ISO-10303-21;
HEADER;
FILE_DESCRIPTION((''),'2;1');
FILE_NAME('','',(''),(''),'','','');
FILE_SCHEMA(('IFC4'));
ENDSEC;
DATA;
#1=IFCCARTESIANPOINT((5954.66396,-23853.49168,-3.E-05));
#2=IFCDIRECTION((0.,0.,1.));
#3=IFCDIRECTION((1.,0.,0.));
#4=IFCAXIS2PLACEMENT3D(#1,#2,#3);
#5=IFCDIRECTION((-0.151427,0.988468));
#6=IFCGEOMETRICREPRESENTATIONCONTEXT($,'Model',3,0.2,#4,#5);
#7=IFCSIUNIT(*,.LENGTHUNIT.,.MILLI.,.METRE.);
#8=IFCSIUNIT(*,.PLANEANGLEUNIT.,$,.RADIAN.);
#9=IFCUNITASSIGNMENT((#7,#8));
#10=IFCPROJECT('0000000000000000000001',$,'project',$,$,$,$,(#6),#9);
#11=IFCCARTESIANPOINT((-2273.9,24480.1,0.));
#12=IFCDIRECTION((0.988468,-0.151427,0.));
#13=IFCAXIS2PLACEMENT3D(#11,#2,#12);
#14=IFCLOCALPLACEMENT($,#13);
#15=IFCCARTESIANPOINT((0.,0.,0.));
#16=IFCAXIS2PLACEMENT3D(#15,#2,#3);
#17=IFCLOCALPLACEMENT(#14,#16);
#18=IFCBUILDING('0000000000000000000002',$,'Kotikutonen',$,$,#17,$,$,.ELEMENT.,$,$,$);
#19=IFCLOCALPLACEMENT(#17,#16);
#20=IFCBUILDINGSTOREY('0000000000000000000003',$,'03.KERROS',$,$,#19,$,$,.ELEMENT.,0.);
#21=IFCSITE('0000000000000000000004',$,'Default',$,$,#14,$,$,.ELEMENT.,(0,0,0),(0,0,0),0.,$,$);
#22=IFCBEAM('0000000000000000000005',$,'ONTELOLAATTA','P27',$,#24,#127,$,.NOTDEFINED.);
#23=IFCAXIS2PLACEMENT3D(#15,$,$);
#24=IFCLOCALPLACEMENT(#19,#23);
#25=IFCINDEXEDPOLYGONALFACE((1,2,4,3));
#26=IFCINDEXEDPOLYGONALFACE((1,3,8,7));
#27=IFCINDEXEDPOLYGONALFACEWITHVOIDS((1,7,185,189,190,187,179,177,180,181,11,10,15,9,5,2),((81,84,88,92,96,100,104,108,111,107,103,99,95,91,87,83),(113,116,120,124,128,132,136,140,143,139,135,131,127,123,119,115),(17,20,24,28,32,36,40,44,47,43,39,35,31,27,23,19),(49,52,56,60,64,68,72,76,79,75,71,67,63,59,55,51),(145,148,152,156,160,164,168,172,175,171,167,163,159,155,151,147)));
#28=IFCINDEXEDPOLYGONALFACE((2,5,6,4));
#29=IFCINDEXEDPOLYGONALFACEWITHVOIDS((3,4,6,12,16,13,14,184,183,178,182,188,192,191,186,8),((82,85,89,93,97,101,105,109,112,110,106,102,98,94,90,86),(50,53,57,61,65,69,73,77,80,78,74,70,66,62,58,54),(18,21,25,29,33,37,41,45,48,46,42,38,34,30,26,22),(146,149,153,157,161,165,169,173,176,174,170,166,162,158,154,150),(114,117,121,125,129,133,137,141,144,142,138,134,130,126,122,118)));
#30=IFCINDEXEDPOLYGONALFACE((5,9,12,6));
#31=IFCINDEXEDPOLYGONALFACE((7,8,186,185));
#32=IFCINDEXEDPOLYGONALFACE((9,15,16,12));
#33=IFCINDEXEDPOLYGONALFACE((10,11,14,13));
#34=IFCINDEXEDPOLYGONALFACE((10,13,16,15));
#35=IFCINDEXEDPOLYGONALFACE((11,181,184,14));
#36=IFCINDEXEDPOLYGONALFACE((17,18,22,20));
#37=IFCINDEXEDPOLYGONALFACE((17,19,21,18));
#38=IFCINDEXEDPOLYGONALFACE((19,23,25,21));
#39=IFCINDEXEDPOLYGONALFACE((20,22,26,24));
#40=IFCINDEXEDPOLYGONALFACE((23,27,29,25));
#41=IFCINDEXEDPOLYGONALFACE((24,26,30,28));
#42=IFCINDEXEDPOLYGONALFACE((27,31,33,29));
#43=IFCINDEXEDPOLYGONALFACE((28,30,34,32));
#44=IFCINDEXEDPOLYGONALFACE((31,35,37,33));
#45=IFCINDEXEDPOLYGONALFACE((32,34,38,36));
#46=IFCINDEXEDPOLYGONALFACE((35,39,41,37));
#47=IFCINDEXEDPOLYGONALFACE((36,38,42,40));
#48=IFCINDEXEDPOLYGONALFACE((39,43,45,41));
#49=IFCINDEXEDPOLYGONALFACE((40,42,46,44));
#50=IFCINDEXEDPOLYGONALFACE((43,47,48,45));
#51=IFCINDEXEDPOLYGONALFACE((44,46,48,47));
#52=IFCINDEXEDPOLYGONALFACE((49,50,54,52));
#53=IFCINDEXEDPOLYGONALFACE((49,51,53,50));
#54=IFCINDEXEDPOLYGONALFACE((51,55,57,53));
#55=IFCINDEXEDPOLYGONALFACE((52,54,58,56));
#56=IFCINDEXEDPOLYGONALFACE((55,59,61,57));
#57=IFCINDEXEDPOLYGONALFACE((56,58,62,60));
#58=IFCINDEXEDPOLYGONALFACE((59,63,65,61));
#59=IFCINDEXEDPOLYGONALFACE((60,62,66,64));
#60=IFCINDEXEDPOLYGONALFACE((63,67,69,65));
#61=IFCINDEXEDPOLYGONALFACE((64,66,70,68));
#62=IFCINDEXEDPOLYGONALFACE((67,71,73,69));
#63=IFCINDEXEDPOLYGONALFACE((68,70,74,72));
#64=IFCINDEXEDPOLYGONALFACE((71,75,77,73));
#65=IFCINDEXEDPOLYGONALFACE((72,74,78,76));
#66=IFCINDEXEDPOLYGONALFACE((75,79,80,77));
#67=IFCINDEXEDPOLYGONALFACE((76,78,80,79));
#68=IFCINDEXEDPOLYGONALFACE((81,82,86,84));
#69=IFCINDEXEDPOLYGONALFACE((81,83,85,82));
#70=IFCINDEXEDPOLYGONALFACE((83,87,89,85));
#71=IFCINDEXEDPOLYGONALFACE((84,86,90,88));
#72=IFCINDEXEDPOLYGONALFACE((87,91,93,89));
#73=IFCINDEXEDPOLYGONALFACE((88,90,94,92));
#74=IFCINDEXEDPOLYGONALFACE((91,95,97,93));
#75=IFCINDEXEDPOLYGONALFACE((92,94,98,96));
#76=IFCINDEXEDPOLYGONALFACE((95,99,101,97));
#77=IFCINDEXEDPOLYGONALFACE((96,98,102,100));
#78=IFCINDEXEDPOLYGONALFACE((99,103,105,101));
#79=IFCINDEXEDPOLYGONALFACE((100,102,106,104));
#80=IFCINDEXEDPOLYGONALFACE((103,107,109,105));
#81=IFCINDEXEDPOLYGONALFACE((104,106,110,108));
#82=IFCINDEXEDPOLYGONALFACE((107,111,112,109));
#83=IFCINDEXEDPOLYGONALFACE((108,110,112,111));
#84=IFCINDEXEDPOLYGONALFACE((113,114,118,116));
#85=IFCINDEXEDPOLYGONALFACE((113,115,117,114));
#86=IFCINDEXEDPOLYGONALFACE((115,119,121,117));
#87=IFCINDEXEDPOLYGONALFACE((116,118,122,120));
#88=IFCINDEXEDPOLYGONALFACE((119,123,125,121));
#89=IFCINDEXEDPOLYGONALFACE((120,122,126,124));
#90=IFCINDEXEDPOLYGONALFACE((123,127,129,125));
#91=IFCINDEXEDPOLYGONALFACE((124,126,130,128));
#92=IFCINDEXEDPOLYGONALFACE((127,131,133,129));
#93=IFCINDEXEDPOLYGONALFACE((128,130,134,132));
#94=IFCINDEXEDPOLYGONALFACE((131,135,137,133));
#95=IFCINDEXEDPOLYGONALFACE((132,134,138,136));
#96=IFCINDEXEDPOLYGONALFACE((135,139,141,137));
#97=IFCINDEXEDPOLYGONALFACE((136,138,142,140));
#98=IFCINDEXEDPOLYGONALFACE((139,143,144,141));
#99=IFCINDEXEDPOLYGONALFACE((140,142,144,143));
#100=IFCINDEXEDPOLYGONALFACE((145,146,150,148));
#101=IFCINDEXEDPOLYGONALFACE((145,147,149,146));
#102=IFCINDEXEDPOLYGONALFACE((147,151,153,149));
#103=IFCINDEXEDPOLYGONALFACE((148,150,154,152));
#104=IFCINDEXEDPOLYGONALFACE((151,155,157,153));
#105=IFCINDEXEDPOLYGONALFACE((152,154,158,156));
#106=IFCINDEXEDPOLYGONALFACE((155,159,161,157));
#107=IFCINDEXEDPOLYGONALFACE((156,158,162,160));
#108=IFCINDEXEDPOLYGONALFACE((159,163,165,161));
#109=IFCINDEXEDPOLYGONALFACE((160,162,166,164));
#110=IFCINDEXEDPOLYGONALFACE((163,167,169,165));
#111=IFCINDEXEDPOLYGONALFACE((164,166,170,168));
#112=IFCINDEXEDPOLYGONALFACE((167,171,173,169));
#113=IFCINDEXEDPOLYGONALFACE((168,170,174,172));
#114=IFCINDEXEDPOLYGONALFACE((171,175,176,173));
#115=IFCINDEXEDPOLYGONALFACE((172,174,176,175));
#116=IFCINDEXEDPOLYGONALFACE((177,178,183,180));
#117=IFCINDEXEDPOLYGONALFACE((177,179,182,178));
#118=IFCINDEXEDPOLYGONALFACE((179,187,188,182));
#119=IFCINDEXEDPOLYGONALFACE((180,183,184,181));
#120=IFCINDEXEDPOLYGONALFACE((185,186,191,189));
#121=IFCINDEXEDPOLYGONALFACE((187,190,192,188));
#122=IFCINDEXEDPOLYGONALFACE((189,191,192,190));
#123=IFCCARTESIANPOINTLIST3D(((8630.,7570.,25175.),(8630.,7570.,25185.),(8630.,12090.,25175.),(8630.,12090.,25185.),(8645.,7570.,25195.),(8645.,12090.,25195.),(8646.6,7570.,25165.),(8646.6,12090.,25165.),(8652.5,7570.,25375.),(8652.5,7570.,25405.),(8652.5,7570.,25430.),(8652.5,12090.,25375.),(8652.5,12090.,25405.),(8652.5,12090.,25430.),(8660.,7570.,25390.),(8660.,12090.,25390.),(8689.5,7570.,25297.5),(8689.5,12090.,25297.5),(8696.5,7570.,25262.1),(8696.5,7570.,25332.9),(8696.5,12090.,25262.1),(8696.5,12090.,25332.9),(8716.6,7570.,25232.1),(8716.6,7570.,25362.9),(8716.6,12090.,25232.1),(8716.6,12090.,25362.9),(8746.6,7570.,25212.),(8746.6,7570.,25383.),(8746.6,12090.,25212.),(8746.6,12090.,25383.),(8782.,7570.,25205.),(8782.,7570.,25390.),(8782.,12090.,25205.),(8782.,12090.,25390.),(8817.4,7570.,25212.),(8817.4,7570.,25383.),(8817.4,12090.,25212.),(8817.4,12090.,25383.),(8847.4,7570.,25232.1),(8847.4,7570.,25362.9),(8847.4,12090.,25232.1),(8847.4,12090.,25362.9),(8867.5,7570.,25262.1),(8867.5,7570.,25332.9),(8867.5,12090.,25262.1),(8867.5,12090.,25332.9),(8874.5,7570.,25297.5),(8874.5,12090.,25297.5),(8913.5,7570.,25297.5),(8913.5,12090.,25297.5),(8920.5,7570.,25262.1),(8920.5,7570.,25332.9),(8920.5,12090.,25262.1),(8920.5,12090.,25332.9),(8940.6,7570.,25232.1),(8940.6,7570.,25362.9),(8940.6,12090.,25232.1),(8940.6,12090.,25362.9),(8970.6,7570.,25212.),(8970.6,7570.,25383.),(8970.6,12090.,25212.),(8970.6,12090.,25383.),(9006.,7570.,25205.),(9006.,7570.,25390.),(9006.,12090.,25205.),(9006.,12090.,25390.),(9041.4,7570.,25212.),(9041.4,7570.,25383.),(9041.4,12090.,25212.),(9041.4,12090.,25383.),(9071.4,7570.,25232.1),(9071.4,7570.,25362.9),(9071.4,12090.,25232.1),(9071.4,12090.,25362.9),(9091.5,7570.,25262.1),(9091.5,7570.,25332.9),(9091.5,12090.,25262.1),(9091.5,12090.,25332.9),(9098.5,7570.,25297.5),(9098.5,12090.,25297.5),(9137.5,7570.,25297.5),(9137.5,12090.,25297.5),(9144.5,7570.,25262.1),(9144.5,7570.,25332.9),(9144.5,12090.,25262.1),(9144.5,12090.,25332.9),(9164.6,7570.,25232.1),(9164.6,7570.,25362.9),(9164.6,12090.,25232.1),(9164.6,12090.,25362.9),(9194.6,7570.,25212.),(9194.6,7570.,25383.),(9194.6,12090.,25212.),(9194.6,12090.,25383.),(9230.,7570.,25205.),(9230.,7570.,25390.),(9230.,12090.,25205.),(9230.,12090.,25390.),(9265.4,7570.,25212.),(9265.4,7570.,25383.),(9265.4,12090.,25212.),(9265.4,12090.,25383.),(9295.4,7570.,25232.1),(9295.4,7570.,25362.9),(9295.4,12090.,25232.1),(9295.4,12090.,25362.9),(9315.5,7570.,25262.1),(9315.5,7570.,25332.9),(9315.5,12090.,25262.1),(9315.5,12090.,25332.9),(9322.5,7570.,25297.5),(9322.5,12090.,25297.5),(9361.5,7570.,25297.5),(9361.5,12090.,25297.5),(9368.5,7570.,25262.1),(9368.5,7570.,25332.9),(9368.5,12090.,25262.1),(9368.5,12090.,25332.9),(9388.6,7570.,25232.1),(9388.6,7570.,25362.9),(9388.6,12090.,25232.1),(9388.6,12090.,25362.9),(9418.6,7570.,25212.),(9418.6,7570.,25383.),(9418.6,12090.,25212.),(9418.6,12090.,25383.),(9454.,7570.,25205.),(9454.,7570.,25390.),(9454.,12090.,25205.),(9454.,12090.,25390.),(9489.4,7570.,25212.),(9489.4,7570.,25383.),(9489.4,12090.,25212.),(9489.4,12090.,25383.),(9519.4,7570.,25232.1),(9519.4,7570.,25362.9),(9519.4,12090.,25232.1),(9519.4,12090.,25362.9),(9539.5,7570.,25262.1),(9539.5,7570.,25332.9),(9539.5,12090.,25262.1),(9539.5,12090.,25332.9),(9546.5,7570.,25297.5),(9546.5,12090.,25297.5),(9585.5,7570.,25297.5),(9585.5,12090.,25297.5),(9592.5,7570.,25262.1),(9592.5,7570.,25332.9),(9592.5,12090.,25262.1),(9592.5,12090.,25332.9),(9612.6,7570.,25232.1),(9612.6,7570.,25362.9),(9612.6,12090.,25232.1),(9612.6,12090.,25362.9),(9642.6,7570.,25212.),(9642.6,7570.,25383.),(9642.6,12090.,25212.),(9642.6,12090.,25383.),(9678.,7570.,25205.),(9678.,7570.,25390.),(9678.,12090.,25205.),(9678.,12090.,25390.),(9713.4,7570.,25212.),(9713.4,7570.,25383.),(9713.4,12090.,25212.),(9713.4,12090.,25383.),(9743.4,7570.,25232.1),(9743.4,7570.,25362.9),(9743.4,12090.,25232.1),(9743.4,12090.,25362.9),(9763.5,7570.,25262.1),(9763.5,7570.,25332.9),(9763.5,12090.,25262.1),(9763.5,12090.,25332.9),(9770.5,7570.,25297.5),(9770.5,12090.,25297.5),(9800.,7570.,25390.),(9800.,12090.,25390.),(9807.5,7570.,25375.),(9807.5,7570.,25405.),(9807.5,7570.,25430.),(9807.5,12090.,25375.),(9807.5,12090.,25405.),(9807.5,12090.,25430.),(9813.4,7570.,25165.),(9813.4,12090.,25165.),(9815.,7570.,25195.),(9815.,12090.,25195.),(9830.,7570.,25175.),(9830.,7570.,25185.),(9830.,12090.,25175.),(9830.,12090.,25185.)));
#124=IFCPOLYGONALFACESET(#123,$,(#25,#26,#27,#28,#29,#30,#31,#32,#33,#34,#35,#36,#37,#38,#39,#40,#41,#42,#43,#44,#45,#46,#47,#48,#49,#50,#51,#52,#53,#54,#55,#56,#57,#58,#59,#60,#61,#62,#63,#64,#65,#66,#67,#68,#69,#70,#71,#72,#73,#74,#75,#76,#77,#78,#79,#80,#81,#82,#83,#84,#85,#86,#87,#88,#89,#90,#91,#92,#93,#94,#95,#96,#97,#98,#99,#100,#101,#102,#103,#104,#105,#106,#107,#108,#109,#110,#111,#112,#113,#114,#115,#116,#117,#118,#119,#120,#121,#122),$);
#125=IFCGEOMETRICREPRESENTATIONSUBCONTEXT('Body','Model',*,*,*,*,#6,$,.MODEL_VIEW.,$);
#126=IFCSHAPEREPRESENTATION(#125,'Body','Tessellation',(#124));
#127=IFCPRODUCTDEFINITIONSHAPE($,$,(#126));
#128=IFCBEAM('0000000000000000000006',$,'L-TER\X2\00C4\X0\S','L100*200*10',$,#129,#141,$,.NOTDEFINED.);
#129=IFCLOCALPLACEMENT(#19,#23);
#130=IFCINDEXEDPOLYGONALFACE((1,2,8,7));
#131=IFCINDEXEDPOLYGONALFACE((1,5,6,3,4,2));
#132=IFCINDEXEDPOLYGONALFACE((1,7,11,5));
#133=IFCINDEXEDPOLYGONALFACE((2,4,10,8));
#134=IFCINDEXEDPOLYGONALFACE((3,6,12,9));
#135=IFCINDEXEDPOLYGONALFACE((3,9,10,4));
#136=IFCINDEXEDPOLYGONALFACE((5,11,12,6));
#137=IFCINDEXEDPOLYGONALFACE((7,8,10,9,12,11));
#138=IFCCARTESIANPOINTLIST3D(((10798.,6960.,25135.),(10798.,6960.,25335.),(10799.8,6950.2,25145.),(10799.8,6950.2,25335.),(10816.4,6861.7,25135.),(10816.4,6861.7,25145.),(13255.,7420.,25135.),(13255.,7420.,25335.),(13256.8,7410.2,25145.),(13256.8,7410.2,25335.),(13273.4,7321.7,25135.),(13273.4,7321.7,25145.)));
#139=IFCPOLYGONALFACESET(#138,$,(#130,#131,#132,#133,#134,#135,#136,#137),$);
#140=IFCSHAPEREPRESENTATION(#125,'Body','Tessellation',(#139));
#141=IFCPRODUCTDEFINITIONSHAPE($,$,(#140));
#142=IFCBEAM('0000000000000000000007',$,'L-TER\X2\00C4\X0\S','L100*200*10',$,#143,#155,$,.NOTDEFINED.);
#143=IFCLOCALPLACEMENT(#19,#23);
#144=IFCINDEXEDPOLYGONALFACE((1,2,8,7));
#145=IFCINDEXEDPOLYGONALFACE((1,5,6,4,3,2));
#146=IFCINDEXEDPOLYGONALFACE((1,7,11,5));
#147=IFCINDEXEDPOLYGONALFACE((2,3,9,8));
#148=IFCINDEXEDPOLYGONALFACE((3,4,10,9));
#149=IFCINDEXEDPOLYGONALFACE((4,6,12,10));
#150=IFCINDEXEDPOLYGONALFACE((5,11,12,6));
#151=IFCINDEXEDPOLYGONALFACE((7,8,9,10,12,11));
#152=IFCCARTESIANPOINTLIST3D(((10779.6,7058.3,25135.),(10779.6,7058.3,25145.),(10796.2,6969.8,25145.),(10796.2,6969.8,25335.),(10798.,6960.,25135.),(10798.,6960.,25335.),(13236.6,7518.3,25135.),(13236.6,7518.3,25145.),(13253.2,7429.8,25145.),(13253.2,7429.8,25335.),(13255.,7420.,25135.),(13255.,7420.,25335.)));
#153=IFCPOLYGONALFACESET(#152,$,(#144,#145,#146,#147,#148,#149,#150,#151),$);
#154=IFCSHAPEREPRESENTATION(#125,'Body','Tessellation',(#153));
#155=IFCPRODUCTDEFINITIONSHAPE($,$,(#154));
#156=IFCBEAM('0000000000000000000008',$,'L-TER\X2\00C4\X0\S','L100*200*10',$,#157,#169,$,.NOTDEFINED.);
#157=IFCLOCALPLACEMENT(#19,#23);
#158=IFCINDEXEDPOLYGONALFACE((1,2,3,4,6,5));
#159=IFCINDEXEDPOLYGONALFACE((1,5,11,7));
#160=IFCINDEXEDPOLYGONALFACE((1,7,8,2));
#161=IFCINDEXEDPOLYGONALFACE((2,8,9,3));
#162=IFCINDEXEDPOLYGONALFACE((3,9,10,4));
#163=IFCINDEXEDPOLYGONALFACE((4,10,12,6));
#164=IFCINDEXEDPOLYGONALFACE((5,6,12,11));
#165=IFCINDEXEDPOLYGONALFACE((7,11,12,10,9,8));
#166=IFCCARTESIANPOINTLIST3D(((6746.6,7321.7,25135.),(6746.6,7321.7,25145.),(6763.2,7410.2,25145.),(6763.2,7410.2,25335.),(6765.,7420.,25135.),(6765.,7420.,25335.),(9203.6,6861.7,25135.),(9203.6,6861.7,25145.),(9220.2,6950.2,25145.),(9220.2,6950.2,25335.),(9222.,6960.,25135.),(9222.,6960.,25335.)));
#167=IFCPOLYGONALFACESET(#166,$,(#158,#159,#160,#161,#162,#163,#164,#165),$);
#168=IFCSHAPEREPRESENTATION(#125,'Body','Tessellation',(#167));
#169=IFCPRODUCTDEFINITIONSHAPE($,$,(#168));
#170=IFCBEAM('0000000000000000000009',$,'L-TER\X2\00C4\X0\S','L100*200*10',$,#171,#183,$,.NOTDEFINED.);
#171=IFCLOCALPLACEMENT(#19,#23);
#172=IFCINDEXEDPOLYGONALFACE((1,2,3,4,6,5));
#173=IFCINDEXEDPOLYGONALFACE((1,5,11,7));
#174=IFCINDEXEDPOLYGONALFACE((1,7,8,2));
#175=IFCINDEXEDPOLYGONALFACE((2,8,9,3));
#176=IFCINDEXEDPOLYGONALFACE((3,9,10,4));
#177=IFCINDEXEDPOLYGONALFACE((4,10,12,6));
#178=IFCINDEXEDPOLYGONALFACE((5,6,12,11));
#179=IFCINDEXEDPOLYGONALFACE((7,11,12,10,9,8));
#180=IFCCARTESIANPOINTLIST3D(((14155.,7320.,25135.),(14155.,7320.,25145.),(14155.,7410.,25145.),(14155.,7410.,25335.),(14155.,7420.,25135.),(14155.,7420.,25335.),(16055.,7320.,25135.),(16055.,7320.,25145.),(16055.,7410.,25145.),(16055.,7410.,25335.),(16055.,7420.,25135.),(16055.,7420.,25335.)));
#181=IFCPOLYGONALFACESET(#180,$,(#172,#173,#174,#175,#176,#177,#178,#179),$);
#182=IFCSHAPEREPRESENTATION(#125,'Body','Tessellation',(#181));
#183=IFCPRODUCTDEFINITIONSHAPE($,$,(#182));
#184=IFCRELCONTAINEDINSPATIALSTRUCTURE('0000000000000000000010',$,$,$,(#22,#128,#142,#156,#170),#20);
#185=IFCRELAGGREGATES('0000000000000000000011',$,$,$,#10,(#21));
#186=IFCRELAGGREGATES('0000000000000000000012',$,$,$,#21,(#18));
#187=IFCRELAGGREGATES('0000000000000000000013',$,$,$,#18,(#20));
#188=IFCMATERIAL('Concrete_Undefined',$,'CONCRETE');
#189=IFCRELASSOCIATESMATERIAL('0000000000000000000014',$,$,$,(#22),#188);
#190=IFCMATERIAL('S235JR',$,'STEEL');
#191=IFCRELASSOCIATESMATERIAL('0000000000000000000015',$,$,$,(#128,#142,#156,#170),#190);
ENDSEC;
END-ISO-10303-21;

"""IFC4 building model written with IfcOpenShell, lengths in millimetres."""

from ifc_helpers import new_model, si_unit, direction, frame, origin_with_axes, place, context, subcontext, project, spatial, line, indexed_curve, outline, extrude, material, element, save


model = new_model("IFC4")

# Units and contexts
model_context = context("Model", 3, precision=0.2, world=frame((5954.66396, -23853.49168, -3e-05), z_axis=(0.0, 0.0, 1.0), x_axis=(1.0, 0.0, 0.0)), true_north=direction((-0.151427, 0.988468)))
body_context = subcontext(model_context, "Body", "Model", "MODEL_VIEW")
ifc_project = project(units=[si_unit("LENGTHUNIT", "METRE", prefix="MILLI"), si_unit("PLANEANGLEUNIT", "RADIAN")], contexts=[model_context])

# Site, building, storey
site_placement = place(None, frame((-2273.9, 24480.1, 0.0), z_axis=(0.0, 0.0, 1.0), x_axis=(0.988468, -0.151427, 0.0)))
site = spatial("IfcSite", under=ifc_project, at=site_placement, Name="Default", CompositionType="ELEMENT", RefLatitude=(0, 0, 0), RefLongitude=(0, 0, 0), RefElevation=0.0)
building_placement = place(site_placement, origin_with_axes())
building = spatial("IfcBuilding", under=site, at=building_placement, Name="Kotikutonen", CompositionType="ELEMENT")
storey_placement = place(building_placement, origin_with_axes())
storey = spatial("IfcBuildingStorey", under=building, at=storey_placement, Name="03.KERROS", CompositionType="ELEMENT", Elevation=0.0)

# Shared definitions
ifc_material_1 = material(Name="Concrete_Undefined", Category="CONCRETE")

# Beams
beam_1_placement = place(storey_placement, frame((9230.0, 12090.0, 25297.5), z_axis=(-1.0, 0.0, 0.0), x_axis=(0.0, -1.0, 0.0)))
element("IfcBeam", 1, at=beam_1_placement, inside=storey, material=ifc_material_1, Name="ONTELOLAATTA", Description="P27", PredefinedType="NOTDEFINED", context=body_context, shape_type="SolidModel", body=[
    extrude(outline(indexed_curve([(-600.0, -122.5), (-583.4, -132.5), (583.4, -132.5), (600.0, -122.5), (600.0, -112.5), (585.0, -102.5), (577.5, 77.5), (570.0, 92.5), (577.5, 107.5), (577.5, 132.5), (-577.5, 132.5), (-577.5, 107.5), (-570.0, 92.5), (-577.5, 77.5), (-585.0, -102.5), (-600.0, -112.5)], segments=[line(1, 2, 3, 4, 5, 6, 7, 8, 9, 10, 11, 12, 13, 14, 15, 16, 1)]), holes=[indexed_curve([(-448.0, -92.5), (-483.4, -85.5), (-513.4, -65.4), (-533.5, -35.4), (-540.5, 0.0), (-533.5, 35.4), (-513.4, 65.4), (-483.4, 85.5), (-448.0, 92.5), (-412.6, 85.5), (-382.6, 65.4), (-362.5, 35.4), (-355.5, 0.0), (-362.5, -35.4), (-382.6, -65.4), (-412.6, -85.5)], segments=[line(1, 2, 3, 4, 5, 6, 7, 8, 9, 10, 11, 12, 13, 14, 15, 16, 1)]), indexed_curve([(-224.0, -92.5), (-259.4, -85.5), (-289.4, -65.4), (-309.5, -35.4), (-316.5, 0.0), (-309.5, 35.4), (-289.4, 65.4), (-259.4, 85.5), (-224.0, 92.5), (-188.6, 85.5), (-158.6, 65.4), (-138.5, 35.4), (-131.5, 0.0), (-138.5, -35.4), (-158.6, -65.4), (-188.6, -85.5)], segments=[line(1, 2, 3, 4, 5, 6, 7, 8, 9, 10, 11, 12, 13, 14, 15, 16, 1)]), indexed_curve([(0.0, -92.5), (-35.4, -85.5), (-65.4, -65.4), (-85.5, -35.4), (-92.5, 0.0), (-85.5, 35.4), (-65.4, 65.4), (-35.4, 85.5), (0.0, 92.5), (35.4, 85.5), (65.4, 65.4), (85.5, 35.4), (92.5, 0.0), (85.5, -35.4), (65.4, -65.4), (35.4, -85.5)], segments=[line(1, 2, 3, 4, 5, 6, 7, 8, 9, 10, 11, 12, 13, 14, 15, 16, 1)]), indexed_curve([(224.0, -92.5), (188.6, -85.5), (158.6, -65.4), (138.5, -35.4), (131.5, 0.0), (138.5, 35.4), (158.6, 65.4), (188.6, 85.5), (224.0, 92.5), (259.4, 85.5), (289.4, 65.4), (309.5, 35.4), (316.5, 0.0), (309.5, -35.4), (289.4, -65.4), (259.4, -85.5)], segments=[line(1, 2, 3, 4, 5, 6, 7, 8, 9, 10, 11, 12, 13, 14, 15, 16, 1)]), indexed_curve([(448.0, -92.5), (412.6, -85.5), (382.6, -65.4), (362.5, -35.4), (355.5, 0.0), (362.5, 35.4), (382.6, 65.4), (412.6, 85.5), (448.0, 92.5), (483.4, 85.5), (513.4, 65.4), (533.5, 35.4), (540.5, 0.0), (533.5, -35.4), (513.4, -65.4), (483.4, -85.5)], segments=[line(1, 2, 3, 4, 5, 6, 7, 8, 9, 10, 11, 12, 13, 14, 15, 16, 1)])]), frame((0.0, 0.0, 0.0), z_axis=(-1.0, 0.0, 0.0), x_axis=(0.0, 0.0, 1.0)), (0.0, 0.0, -1.0), 4520.0),
])
ifc_material_2 = material(Name="S235JR", Category="STEEL")
for number, where, z_axis, x_axis, name in (
    (2, (13264.2, 7370.9, 25235.0), (0.0, 0.0, 1.0), (-0.982922, -0.184023, 0.0), "L-TERÄS"),
    (3, (10788.8, 7009.1, 25235.0), (0.0, 0.0, 1.0), (0.982922, 0.184023, 0.0), "L-TERÄS"),
    (4, (9212.8, 6910.9, 25235.0), (0.0, 0.0, 1.0), (-0.982922, 0.184023, 0.0), "L-TERÄS"),
):
    element("IfcBeam", number, at=place(storey_placement, frame(where, z_axis=z_axis, x_axis=x_axis)), inside=storey, material=ifc_material_2, Name=name, Description="L100*200*10", PredefinedType="NOTDEFINED", context=body_context, shape_type="SolidModel", body=[
        extrude(outline(indexed_curve([(-100.0, -50.0), (100.0, -50.0), (100.0, -40.0), (-90.0, -40.0), (-90.0, 50.0), (-100.0, 50.0)], segments=[line(1, 2, 3, 4, 5, 6, 1)])), frame((0.0, 0.0, 0.0), z_axis=(-1.0, 0.0, 0.0), x_axis=(0.0, 0.0, 1.0)), (0.0, 0.0, -1.0), 2499.7),
    ])
for number, where, z_axis, x_axis, name in (
    (5, (16055.0, 7370.0, 25235.0), (0.0, 0.0, 1.0), (-1.0, 0.0, 0.0), "L-TERÄS"),
):
    element("IfcBeam", number, at=place(storey_placement, frame(where, z_axis=z_axis, x_axis=x_axis)), inside=storey, material=ifc_material_2, Name=name, Description="L100*200*10", PredefinedType="NOTDEFINED", context=body_context, shape_type="SolidModel", body=[
        extrude(outline(indexed_curve([(-100.0, -50.0), (100.0, -50.0), (100.0, -40.0), (-90.0, -40.0), (-90.0, 50.0), (-100.0, 50.0)], segments=[line(1, 2, 3, 4, 5, 6, 1)])), frame((0.0, 0.0, 0.0), z_axis=(-1.0, 0.0, 0.0), x_axis=(0.0, 0.0, 1.0)), (0.0, 0.0, -1.0), 1900.0),
    ])

save(model, "model.ifc")
